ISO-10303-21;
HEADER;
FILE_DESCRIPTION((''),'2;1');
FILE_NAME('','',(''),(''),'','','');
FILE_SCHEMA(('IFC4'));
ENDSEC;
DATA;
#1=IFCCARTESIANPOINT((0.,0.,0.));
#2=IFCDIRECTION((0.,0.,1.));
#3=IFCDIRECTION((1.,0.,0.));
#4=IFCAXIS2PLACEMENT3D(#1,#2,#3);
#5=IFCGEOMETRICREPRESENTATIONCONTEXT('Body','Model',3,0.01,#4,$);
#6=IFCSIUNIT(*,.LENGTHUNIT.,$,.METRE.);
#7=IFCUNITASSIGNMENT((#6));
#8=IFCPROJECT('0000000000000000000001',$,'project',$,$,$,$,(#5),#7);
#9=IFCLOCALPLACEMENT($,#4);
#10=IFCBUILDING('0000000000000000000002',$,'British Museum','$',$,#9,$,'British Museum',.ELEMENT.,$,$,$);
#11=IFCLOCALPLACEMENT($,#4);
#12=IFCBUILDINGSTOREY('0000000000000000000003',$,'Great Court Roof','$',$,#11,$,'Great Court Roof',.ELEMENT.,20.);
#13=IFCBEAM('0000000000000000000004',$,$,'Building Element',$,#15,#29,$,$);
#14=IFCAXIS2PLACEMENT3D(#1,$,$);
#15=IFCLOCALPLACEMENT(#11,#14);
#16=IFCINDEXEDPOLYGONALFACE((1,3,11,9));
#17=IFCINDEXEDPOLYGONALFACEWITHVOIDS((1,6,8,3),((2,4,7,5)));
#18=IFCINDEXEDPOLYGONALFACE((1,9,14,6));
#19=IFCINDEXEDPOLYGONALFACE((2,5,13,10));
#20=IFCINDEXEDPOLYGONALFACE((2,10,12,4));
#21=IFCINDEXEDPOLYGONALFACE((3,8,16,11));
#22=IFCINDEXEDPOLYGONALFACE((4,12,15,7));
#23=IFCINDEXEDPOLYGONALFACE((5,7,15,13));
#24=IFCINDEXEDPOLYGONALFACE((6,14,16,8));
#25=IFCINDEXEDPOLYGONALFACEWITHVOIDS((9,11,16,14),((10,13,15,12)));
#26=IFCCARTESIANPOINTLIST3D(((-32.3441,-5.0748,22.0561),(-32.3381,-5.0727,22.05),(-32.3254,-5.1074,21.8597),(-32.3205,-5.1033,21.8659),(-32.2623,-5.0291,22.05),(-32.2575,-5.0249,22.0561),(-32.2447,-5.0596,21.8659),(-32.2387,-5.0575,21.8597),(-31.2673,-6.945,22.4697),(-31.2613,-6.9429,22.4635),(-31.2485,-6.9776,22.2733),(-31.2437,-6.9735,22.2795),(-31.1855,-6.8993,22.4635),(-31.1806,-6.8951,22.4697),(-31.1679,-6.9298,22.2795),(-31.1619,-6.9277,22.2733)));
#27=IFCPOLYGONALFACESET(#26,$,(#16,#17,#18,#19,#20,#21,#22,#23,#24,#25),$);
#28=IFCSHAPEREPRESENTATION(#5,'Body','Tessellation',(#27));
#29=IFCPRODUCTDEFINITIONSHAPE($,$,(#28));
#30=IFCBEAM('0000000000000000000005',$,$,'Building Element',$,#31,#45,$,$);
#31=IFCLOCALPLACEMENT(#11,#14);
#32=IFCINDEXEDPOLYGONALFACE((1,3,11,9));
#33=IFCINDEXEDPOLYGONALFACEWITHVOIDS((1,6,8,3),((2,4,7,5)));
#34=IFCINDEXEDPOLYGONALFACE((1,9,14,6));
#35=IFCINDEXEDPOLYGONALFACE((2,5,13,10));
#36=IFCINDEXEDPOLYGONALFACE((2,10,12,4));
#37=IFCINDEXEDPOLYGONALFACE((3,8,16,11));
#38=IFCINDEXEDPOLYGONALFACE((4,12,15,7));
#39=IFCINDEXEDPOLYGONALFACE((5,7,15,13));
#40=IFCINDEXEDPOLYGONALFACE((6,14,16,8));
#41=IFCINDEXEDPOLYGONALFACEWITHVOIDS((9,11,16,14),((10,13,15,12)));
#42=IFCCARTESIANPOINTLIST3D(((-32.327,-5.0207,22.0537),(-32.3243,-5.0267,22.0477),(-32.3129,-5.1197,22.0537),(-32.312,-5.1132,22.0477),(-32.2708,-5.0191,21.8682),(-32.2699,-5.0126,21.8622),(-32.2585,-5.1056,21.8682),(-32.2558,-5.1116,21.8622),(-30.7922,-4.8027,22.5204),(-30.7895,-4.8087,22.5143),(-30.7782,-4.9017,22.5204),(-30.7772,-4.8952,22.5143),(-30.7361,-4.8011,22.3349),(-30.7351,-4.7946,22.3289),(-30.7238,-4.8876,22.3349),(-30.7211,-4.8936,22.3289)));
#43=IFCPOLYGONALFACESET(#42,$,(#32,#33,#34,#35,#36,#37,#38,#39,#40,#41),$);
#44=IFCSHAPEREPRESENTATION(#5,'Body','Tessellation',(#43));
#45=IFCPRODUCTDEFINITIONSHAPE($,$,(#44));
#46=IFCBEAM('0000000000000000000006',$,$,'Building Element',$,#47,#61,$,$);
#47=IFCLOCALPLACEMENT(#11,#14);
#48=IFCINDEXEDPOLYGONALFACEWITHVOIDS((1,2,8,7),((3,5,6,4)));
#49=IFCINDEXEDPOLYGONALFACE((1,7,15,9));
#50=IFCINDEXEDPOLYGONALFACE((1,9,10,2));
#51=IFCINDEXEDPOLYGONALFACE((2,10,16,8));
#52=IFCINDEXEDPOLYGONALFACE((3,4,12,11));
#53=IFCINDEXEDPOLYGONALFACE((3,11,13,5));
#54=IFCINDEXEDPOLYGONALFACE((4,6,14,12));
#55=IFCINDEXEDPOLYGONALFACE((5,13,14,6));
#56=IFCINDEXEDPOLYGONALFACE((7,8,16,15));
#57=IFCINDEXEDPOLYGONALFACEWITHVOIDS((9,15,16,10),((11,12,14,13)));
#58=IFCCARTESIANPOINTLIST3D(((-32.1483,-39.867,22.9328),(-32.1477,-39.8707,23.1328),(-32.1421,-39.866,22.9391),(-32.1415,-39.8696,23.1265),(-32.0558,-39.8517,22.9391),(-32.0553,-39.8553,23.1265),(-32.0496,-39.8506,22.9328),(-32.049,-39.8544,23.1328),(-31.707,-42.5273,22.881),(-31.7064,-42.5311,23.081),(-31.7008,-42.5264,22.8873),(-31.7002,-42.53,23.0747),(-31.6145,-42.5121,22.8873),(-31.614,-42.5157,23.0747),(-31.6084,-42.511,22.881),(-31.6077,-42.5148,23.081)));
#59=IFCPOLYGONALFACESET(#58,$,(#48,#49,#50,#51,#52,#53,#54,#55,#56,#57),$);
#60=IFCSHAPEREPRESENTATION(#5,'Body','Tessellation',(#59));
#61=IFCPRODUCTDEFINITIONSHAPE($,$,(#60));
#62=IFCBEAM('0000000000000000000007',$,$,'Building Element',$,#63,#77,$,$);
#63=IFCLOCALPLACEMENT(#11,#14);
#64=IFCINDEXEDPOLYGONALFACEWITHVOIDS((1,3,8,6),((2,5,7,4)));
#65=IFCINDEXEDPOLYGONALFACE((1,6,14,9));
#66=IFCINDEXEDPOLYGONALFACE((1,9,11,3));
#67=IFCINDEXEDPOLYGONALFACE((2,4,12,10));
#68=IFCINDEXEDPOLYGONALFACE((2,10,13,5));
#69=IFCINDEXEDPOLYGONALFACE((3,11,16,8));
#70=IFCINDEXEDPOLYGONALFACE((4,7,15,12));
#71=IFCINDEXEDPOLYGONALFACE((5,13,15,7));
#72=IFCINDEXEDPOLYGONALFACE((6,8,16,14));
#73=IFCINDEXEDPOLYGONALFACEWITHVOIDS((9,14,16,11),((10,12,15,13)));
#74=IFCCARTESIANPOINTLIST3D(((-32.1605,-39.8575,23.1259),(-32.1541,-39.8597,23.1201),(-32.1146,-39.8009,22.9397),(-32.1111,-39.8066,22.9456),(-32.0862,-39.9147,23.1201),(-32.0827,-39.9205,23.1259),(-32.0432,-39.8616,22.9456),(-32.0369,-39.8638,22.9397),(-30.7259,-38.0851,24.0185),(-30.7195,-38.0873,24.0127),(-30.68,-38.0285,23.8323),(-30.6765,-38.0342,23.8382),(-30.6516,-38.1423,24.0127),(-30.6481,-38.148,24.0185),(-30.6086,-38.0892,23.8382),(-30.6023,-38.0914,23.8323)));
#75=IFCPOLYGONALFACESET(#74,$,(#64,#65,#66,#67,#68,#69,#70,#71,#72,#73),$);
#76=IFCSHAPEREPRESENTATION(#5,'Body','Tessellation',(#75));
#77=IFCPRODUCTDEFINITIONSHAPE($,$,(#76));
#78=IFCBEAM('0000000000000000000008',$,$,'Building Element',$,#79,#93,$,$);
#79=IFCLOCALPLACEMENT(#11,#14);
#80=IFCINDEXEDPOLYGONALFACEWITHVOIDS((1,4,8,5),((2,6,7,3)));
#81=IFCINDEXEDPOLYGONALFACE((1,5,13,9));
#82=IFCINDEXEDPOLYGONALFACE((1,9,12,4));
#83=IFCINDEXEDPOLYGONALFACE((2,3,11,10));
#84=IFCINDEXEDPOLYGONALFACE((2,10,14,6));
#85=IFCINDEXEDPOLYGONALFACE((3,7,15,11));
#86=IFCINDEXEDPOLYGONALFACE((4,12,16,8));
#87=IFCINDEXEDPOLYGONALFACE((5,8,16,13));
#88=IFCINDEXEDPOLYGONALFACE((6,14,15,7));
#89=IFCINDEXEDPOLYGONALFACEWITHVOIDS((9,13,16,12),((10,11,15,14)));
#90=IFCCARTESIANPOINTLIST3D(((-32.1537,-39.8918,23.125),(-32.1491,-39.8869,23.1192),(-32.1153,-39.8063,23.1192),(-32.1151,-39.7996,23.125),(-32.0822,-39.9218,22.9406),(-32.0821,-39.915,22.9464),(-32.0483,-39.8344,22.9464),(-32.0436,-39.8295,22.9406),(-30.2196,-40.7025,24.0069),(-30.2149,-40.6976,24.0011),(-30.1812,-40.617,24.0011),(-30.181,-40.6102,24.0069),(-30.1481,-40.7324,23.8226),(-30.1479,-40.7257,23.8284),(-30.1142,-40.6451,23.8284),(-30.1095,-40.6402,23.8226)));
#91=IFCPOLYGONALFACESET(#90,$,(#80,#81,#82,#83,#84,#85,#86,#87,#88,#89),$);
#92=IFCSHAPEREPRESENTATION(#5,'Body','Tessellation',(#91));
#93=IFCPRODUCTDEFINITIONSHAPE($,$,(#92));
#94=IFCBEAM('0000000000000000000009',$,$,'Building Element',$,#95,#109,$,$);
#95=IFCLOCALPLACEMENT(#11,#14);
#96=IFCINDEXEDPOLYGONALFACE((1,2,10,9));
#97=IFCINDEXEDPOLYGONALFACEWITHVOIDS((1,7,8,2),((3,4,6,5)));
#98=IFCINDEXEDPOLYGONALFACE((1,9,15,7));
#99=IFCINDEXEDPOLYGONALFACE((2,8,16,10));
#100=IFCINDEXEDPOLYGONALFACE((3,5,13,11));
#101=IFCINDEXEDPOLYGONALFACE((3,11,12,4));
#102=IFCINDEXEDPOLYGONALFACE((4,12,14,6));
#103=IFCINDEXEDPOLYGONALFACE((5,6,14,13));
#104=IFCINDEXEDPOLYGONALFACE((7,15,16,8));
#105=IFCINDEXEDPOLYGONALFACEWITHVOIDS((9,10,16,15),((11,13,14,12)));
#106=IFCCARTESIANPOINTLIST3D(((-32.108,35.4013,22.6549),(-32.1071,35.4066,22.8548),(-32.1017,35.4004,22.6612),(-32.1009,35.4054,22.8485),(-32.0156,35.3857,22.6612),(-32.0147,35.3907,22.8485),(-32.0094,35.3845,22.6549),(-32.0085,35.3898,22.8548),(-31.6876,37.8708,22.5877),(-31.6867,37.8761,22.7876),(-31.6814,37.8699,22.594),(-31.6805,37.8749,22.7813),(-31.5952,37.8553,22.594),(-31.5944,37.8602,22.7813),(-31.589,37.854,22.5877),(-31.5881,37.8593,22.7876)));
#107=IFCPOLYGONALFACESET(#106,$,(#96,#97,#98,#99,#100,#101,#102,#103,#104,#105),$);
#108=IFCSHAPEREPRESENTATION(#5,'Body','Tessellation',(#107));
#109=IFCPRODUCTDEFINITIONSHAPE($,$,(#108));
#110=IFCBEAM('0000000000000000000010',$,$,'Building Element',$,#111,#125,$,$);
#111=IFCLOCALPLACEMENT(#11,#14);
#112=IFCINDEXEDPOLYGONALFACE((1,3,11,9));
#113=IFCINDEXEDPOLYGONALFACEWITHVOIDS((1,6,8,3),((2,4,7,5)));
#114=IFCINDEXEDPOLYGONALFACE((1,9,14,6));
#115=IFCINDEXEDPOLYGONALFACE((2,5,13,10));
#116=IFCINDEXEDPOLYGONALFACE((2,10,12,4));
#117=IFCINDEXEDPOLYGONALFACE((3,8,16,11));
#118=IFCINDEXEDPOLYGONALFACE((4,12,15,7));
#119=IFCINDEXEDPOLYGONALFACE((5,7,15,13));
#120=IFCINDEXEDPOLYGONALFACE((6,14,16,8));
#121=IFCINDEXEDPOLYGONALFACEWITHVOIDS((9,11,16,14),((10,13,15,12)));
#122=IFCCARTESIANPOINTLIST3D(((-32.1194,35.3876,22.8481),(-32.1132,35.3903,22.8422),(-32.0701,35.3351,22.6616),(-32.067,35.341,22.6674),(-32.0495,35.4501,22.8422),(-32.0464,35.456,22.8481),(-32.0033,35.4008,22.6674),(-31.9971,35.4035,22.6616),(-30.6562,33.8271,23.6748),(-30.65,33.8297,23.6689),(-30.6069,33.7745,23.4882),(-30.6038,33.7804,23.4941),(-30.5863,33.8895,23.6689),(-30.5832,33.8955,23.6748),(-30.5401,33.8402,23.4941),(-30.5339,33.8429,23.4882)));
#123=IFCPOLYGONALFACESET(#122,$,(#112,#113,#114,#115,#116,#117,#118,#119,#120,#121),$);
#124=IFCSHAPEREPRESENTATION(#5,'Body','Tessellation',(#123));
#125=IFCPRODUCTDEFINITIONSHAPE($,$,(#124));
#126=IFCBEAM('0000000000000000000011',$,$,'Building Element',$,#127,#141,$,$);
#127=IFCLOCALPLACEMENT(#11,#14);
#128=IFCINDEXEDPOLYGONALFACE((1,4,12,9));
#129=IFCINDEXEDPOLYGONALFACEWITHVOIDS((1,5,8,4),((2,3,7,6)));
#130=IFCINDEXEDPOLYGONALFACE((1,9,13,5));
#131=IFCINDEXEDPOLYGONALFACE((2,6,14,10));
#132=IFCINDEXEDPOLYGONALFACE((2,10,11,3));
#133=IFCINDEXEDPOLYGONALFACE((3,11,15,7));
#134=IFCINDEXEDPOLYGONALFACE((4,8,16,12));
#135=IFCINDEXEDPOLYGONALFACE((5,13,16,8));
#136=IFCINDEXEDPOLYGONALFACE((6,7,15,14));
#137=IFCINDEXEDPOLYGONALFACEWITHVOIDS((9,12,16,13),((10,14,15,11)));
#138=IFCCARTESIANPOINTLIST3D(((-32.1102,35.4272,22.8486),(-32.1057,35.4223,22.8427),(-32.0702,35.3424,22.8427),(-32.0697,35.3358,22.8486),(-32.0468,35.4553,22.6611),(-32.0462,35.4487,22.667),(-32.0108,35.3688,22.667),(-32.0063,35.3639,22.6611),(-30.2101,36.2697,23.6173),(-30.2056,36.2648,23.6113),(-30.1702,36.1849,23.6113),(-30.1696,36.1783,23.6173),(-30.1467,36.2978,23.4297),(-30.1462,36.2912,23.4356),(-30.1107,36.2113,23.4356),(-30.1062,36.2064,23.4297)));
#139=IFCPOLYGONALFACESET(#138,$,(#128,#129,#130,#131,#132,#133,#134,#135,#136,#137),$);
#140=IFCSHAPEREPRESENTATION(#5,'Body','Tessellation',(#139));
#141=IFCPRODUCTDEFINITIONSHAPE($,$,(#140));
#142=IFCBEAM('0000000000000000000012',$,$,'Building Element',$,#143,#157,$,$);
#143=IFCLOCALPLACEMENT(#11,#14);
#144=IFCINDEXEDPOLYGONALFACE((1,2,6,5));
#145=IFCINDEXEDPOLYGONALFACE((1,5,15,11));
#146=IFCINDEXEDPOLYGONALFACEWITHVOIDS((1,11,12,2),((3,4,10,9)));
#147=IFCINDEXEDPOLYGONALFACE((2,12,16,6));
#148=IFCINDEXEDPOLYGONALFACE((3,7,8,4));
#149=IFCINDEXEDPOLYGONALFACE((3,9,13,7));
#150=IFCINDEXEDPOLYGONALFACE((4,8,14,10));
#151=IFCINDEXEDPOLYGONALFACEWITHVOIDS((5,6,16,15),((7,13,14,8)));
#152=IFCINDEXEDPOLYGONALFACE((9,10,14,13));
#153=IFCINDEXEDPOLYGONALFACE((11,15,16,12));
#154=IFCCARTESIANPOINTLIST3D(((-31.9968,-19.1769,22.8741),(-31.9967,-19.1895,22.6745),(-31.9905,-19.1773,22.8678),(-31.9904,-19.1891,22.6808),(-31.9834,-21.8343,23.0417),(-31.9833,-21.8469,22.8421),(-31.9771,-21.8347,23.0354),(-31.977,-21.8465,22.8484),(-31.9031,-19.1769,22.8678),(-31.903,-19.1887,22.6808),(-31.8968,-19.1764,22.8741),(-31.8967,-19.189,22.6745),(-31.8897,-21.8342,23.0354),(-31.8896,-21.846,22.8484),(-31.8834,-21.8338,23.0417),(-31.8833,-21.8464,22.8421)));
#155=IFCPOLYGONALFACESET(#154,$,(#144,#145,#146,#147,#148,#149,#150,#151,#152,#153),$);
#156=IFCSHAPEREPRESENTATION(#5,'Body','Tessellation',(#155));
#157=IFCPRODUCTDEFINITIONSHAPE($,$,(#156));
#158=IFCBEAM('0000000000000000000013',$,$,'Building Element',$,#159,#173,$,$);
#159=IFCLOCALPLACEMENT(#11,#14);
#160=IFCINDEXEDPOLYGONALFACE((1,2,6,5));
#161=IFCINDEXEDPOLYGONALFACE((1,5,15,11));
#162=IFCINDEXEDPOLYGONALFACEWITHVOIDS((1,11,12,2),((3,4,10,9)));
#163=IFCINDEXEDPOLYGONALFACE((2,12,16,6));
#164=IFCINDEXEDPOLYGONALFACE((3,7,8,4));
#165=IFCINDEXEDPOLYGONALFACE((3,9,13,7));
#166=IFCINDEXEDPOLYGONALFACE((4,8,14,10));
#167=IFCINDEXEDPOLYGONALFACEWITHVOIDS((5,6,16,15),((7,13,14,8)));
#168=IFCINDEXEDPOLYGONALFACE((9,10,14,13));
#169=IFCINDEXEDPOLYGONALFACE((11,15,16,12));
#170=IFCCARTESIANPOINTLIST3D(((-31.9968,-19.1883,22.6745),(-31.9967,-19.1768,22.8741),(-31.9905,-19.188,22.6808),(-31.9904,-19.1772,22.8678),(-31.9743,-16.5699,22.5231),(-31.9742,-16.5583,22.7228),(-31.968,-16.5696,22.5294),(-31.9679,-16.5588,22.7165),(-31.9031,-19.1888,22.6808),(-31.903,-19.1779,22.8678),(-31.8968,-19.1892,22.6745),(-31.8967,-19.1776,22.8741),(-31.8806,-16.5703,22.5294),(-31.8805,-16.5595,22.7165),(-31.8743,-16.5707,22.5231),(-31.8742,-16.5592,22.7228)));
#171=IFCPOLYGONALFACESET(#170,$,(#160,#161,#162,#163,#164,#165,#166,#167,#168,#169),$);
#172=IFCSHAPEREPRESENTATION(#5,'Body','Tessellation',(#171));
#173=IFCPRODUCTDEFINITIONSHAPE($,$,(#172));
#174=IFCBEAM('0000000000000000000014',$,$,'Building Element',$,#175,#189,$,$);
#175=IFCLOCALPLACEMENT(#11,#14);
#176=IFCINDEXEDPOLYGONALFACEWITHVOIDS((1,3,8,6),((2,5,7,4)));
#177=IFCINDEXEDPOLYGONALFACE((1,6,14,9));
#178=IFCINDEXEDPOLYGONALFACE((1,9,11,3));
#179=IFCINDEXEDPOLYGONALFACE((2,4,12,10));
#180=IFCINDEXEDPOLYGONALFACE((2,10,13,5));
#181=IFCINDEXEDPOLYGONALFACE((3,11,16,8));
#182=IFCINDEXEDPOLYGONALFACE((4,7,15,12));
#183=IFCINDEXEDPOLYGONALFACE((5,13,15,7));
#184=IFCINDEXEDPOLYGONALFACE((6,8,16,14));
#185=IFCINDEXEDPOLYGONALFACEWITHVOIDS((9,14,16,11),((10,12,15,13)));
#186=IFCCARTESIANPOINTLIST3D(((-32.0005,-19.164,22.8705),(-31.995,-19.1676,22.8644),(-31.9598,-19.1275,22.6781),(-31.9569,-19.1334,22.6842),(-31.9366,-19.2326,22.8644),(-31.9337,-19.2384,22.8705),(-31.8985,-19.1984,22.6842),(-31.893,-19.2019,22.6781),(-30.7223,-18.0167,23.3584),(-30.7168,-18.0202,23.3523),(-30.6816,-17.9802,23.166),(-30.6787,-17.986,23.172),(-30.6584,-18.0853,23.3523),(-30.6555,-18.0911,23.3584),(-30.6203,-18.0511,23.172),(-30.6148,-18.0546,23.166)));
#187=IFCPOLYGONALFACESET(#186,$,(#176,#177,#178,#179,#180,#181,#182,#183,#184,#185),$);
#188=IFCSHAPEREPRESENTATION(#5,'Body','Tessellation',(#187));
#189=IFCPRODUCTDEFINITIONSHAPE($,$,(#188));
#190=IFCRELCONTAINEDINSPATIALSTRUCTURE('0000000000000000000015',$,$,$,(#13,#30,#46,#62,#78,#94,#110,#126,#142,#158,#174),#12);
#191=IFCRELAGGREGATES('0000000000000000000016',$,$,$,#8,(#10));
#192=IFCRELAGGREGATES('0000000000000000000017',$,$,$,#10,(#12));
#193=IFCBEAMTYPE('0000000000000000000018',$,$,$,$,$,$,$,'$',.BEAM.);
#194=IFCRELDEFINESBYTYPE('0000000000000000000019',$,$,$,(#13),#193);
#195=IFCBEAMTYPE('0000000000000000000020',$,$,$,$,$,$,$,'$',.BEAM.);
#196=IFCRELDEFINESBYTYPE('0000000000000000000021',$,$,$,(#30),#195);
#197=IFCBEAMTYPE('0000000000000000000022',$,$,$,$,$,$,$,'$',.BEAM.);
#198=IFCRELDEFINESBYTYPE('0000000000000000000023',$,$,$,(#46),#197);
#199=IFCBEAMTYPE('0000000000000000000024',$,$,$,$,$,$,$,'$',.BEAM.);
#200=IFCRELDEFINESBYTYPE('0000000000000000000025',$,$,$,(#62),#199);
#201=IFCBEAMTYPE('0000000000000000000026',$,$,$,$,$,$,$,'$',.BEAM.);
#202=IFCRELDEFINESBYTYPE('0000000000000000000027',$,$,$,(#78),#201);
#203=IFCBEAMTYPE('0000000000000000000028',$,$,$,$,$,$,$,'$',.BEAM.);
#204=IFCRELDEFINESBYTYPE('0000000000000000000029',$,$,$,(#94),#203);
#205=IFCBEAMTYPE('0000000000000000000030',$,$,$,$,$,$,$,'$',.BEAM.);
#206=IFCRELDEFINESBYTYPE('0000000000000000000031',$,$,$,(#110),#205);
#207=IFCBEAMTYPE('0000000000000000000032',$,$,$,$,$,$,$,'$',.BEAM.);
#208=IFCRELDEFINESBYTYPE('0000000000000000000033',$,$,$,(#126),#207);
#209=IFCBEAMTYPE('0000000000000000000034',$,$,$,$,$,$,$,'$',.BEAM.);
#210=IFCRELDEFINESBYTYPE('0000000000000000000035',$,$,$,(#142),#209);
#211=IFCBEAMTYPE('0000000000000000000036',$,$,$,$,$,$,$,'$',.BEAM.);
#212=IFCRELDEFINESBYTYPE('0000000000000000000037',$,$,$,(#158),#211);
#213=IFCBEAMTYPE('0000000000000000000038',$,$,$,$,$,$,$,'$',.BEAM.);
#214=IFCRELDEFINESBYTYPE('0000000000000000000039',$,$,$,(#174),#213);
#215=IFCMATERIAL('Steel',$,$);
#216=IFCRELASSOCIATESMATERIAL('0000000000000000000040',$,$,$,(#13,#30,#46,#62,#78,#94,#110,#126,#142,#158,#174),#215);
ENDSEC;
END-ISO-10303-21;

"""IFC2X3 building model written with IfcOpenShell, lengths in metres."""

from ifc_helpers import new_model, si_unit, frame, origin_with_axes, origin_2d, place, context, project, spatial, hollow_rectangle, extrude, material, type_object, element, save


model = new_model("IFC2X3")

# Units and contexts
model_context = context("Model", 3, precision=0.01, world=origin_with_axes(), identifier="Body")
ifc_project = project(units=[si_unit("LENGTHUNIT", "METRE")], contexts=[model_context])

# Building, storey
building_placement = place(None, origin_with_axes())
building = spatial("IfcBuilding", under=ifc_project, at=building_placement, Name="British Museum", Description="$", LongName="British Museum", CompositionType="ELEMENT")
storey_placement = place(None, origin_with_axes())
storey = spatial("IfcBuildingStorey", under=building, at=storey_placement, Name="Great Court Roof", Description="$", LongName="Great Court Roof", CompositionType="ELEMENT", Elevation=20.0)

# Beams
ifc_material = material(Name="Steel")
beam_type_1 = type_object("IfcBeamType", ElementType="$", PredefinedType="BEAM")
beam_1_placement = place(None, origin_with_axes())
element("IfcBeam", 1, at=beam_1_placement, inside=storey, type_object=beam_type_1, material=ifc_material, Description="Building Element", context=model_context, shape_type="SweptSolid", body=[
    extrude(hollow_rectangle(XDim=0.1, YDim=0.2, WallThickness=0.0063, InnerFilletRadius=-0.0063, OuterFilletRadius=0.0, at=origin_2d()), frame((-32.2914, -5.0662, 21.9579), z_axis=(0.490065, -0.851122, 0.188222), x_axis=(0.866611, 0.498984, 0.0)), (0.0, 0.0, 1.0), 2.1973),
])
beam_type_2 = type_object("IfcBeamType", ElementType="$", PredefinedType="BEAM")
beam_2_placement = place(None, origin_with_axes())
element("IfcBeam", 2, at=beam_2_placement, inside=storey, type_object=beam_type_2, material=ifc_material, Description="Building Element", context=model_context, shape_type="SweptSolid", body=[
    extrude(hollow_rectangle(XDim=0.1, YDim=0.2, WallThickness=0.0063, InnerFilletRadius=-0.0063, OuterFilletRadius=0.0, at=origin_2d()), frame((-32.2914, -5.0662, 21.9579), z_axis=(0.948033, 0.134667, 0.288269), x_axis=(-0.140637, 0.990061, 0.0)), (0.0, 0.0, 1.0), 1.6189),
])
beam_type_3 = type_object("IfcBeamType", ElementType="$", PredefinedType="BEAM")
beam_3_placement = place(None, origin_with_axes())
element("IfcBeam", 3, at=beam_3_placement, inside=storey, type_object=beam_type_3, material=ifc_material, Description="Building Element", context=model_context, shape_type="SweptSolid", body=[
    extrude(hollow_rectangle(XDim=0.1, YDim=0.2, WallThickness=0.0063, InnerFilletRadius=-0.0063, OuterFilletRadius=0.0, at=origin_2d()), frame((-32.0987, -39.8607, 23.0328), z_axis=(0.16361, -0.986338, -0.019212), x_axis=(0.98652, 0.163641, 0.0)), (0.0, 0.0, 1.0), 2.6972),
])
beam_type_4 = type_object("IfcBeamType", ElementType="$", PredefinedType="BEAM")
beam_4_placement = place(None, origin_with_axes())
element("IfcBeam", 4, at=beam_4_placement, inside=storey, type_object=beam_type_4, material=ifc_material, Description="Building Element", context=model_context, shape_type="SweptSolid", body=[
    extrude(hollow_rectangle(XDim=0.1, YDim=0.2, WallThickness=0.0063, InnerFilletRadius=-0.0063, OuterFilletRadius=0.0, at=origin_2d()), frame((-32.0987, -39.8607, 23.0328), z_axis=(0.58585, 0.723812, 0.364522), x_axis=(-0.777294, 0.629138, 0.0)), (0.0, 0.0, 1.0), 2.4487),
])
beam_type_5 = type_object("IfcBeamType", ElementType="$", PredefinedType="BEAM")
beam_5_placement = place(None, origin_with_axes())
element("IfcBeam", 5, at=beam_5_placement, inside=storey, type_object=beam_type_5, material=ifc_material, Description="Building Element", context=model_context, shape_type="SweptSolid", body=[
    extrude(hollow_rectangle(XDim=0.1, YDim=0.2, WallThickness=0.0063, InnerFilletRadius=-0.0063, OuterFilletRadius=0.0, at=origin_2d()), frame((-32.0987, -39.8607, 23.0328), z_axis=(0.850147, -0.356328, 0.38766), x_axis=(0.386556, 0.922266, 0.0)), (0.0, 0.0, 1.0), 2.275),
])
beam_type_6 = type_object("IfcBeamType", ElementType="$", PredefinedType="BEAM")
beam_6_placement = place(None, origin_with_axes())
element("IfcBeam", 6, at=beam_6_placement, inside=storey, type_object=beam_type_6, material=ifc_material, Description="Building Element", context=model_context, shape_type="SweptSolid", body=[
    extrude(hollow_rectangle(XDim=0.1, YDim=0.2, WallThickness=0.0063, InnerFilletRadius=-0.0063, OuterFilletRadius=0.0, at=origin_2d()), frame((-32.0582, 35.3956, 22.7548), z_axis=(0.167754, 0.985464, -0.026821), x_axis=(-0.985819, 0.167814, 0.0)), (0.0, 0.0, 1.0), 2.506),
])
beam_type_7 = type_object("IfcBeamType", ElementType="$", PredefinedType="BEAM")
beam_7_placement = place(None, origin_with_axes())
element("IfcBeam", 7, at=beam_7_placement, inside=storey, type_object=beam_type_7, material=ifc_material, Description="Building Element", context=model_context, shape_type="SweptSolid", body=[
    extrude(hollow_rectangle(XDim=0.1, YDim=0.2, WallThickness=0.0063, InnerFilletRadius=-0.0063, OuterFilletRadius=0.0, at=origin_2d()), frame((-32.0582, 35.3956, 22.7548), z_axis=(0.638, -0.680461, 0.360458), x_axis=(0.729501, 0.68398, 0.0)), (0.0, 0.0, 1.0), 2.2934),
])
beam_type_8 = type_object("IfcBeamType", ElementType="$", PredefinedType="BEAM")
beam_8_placement = place(None, origin_with_axes())
element("IfcBeam", 8, at=beam_8_placement, inside=storey, type_object=beam_type_8, material=ifc_material, Description="Building Element", context=model_context, shape_type="SweptSolid", body=[
    extrude(hollow_rectangle(XDim=0.1, YDim=0.2, WallThickness=0.0063, InnerFilletRadius=-0.0063, OuterFilletRadius=0.0, at=origin_2d()), frame((-32.0582, 35.3956, 22.7548), z_axis=(0.857418, 0.380181, 0.346839), x_axis=(-0.405342, 0.914165, 0.0)), (0.0, 0.0, 1.0), 2.216),
])
beam_type_9 = type_object("IfcBeamType", ElementType="$", PredefinedType="BEAM")
beam_9_placement = place(None, origin_with_axes())
element("IfcBeam", 9, at=beam_9_placement, inside=storey, type_object=beam_type_9, material=ifc_material, Description="Building Element", context=model_context, shape_type="SweptSolid", body=[
    extrude(hollow_rectangle(XDim=0.1, YDim=0.2, WallThickness=0.0063, InnerFilletRadius=-0.0063, OuterFilletRadius=0.0, at=origin_2d()), frame((-31.9468, -19.183, 22.7743), z_axis=(0.005034, -0.998005, 0.062935), x_axis=(0.999987, 0.005044, 0.0)), (0.0, 0.0, 1.0), 2.6627),
])
beam_type_10 = type_object("IfcBeamType", ElementType="$", PredefinedType="BEAM")
beam_10_placement = place(None, origin_with_axes())
element("IfcBeam", 10, at=beam_10_placement, inside=storey, type_object=beam_type_10, material=ifc_material, Description="Building Element", context=model_context, shape_type="SweptSolid", body=[
    extrude(hollow_rectangle(XDim=0.1, YDim=0.2, WallThickness=0.0063, InnerFilletRadius=-0.0063, OuterFilletRadius=0.0, at=origin_2d()), frame((-31.9468, -19.183, 22.7743), z_axis=(0.008597, 0.998297, -0.057691), x_axis=(-0.999963, 0.008611, 0.0)), (0.0, 0.0, 1.0), 2.6229),
])
beam_type_11 = type_object("IfcBeamType", ElementType="$", PredefinedType="BEAM")
beam_11_placement = place(None, origin_with_axes())
element("IfcBeam", 11, at=beam_11_placement, inside=storey, type_object=beam_type_11, material=ifc_material, Description="Building Element", context=model_context, shape_type="SweptSolid", body=[
    extrude(hollow_rectangle(XDim=0.1, YDim=0.2, WallThickness=0.0063, InnerFilletRadius=-0.0063, OuterFilletRadius=0.0, at=origin_2d()), frame((-31.9468, -19.183, 22.7743), z_axis=(0.715866, 0.642562, 0.273223), x_axis=(-0.667978, 0.744181, 0.0)), (0.0, 0.0, 1.0), 1.7856),
])

save(model, "model.ifc")
